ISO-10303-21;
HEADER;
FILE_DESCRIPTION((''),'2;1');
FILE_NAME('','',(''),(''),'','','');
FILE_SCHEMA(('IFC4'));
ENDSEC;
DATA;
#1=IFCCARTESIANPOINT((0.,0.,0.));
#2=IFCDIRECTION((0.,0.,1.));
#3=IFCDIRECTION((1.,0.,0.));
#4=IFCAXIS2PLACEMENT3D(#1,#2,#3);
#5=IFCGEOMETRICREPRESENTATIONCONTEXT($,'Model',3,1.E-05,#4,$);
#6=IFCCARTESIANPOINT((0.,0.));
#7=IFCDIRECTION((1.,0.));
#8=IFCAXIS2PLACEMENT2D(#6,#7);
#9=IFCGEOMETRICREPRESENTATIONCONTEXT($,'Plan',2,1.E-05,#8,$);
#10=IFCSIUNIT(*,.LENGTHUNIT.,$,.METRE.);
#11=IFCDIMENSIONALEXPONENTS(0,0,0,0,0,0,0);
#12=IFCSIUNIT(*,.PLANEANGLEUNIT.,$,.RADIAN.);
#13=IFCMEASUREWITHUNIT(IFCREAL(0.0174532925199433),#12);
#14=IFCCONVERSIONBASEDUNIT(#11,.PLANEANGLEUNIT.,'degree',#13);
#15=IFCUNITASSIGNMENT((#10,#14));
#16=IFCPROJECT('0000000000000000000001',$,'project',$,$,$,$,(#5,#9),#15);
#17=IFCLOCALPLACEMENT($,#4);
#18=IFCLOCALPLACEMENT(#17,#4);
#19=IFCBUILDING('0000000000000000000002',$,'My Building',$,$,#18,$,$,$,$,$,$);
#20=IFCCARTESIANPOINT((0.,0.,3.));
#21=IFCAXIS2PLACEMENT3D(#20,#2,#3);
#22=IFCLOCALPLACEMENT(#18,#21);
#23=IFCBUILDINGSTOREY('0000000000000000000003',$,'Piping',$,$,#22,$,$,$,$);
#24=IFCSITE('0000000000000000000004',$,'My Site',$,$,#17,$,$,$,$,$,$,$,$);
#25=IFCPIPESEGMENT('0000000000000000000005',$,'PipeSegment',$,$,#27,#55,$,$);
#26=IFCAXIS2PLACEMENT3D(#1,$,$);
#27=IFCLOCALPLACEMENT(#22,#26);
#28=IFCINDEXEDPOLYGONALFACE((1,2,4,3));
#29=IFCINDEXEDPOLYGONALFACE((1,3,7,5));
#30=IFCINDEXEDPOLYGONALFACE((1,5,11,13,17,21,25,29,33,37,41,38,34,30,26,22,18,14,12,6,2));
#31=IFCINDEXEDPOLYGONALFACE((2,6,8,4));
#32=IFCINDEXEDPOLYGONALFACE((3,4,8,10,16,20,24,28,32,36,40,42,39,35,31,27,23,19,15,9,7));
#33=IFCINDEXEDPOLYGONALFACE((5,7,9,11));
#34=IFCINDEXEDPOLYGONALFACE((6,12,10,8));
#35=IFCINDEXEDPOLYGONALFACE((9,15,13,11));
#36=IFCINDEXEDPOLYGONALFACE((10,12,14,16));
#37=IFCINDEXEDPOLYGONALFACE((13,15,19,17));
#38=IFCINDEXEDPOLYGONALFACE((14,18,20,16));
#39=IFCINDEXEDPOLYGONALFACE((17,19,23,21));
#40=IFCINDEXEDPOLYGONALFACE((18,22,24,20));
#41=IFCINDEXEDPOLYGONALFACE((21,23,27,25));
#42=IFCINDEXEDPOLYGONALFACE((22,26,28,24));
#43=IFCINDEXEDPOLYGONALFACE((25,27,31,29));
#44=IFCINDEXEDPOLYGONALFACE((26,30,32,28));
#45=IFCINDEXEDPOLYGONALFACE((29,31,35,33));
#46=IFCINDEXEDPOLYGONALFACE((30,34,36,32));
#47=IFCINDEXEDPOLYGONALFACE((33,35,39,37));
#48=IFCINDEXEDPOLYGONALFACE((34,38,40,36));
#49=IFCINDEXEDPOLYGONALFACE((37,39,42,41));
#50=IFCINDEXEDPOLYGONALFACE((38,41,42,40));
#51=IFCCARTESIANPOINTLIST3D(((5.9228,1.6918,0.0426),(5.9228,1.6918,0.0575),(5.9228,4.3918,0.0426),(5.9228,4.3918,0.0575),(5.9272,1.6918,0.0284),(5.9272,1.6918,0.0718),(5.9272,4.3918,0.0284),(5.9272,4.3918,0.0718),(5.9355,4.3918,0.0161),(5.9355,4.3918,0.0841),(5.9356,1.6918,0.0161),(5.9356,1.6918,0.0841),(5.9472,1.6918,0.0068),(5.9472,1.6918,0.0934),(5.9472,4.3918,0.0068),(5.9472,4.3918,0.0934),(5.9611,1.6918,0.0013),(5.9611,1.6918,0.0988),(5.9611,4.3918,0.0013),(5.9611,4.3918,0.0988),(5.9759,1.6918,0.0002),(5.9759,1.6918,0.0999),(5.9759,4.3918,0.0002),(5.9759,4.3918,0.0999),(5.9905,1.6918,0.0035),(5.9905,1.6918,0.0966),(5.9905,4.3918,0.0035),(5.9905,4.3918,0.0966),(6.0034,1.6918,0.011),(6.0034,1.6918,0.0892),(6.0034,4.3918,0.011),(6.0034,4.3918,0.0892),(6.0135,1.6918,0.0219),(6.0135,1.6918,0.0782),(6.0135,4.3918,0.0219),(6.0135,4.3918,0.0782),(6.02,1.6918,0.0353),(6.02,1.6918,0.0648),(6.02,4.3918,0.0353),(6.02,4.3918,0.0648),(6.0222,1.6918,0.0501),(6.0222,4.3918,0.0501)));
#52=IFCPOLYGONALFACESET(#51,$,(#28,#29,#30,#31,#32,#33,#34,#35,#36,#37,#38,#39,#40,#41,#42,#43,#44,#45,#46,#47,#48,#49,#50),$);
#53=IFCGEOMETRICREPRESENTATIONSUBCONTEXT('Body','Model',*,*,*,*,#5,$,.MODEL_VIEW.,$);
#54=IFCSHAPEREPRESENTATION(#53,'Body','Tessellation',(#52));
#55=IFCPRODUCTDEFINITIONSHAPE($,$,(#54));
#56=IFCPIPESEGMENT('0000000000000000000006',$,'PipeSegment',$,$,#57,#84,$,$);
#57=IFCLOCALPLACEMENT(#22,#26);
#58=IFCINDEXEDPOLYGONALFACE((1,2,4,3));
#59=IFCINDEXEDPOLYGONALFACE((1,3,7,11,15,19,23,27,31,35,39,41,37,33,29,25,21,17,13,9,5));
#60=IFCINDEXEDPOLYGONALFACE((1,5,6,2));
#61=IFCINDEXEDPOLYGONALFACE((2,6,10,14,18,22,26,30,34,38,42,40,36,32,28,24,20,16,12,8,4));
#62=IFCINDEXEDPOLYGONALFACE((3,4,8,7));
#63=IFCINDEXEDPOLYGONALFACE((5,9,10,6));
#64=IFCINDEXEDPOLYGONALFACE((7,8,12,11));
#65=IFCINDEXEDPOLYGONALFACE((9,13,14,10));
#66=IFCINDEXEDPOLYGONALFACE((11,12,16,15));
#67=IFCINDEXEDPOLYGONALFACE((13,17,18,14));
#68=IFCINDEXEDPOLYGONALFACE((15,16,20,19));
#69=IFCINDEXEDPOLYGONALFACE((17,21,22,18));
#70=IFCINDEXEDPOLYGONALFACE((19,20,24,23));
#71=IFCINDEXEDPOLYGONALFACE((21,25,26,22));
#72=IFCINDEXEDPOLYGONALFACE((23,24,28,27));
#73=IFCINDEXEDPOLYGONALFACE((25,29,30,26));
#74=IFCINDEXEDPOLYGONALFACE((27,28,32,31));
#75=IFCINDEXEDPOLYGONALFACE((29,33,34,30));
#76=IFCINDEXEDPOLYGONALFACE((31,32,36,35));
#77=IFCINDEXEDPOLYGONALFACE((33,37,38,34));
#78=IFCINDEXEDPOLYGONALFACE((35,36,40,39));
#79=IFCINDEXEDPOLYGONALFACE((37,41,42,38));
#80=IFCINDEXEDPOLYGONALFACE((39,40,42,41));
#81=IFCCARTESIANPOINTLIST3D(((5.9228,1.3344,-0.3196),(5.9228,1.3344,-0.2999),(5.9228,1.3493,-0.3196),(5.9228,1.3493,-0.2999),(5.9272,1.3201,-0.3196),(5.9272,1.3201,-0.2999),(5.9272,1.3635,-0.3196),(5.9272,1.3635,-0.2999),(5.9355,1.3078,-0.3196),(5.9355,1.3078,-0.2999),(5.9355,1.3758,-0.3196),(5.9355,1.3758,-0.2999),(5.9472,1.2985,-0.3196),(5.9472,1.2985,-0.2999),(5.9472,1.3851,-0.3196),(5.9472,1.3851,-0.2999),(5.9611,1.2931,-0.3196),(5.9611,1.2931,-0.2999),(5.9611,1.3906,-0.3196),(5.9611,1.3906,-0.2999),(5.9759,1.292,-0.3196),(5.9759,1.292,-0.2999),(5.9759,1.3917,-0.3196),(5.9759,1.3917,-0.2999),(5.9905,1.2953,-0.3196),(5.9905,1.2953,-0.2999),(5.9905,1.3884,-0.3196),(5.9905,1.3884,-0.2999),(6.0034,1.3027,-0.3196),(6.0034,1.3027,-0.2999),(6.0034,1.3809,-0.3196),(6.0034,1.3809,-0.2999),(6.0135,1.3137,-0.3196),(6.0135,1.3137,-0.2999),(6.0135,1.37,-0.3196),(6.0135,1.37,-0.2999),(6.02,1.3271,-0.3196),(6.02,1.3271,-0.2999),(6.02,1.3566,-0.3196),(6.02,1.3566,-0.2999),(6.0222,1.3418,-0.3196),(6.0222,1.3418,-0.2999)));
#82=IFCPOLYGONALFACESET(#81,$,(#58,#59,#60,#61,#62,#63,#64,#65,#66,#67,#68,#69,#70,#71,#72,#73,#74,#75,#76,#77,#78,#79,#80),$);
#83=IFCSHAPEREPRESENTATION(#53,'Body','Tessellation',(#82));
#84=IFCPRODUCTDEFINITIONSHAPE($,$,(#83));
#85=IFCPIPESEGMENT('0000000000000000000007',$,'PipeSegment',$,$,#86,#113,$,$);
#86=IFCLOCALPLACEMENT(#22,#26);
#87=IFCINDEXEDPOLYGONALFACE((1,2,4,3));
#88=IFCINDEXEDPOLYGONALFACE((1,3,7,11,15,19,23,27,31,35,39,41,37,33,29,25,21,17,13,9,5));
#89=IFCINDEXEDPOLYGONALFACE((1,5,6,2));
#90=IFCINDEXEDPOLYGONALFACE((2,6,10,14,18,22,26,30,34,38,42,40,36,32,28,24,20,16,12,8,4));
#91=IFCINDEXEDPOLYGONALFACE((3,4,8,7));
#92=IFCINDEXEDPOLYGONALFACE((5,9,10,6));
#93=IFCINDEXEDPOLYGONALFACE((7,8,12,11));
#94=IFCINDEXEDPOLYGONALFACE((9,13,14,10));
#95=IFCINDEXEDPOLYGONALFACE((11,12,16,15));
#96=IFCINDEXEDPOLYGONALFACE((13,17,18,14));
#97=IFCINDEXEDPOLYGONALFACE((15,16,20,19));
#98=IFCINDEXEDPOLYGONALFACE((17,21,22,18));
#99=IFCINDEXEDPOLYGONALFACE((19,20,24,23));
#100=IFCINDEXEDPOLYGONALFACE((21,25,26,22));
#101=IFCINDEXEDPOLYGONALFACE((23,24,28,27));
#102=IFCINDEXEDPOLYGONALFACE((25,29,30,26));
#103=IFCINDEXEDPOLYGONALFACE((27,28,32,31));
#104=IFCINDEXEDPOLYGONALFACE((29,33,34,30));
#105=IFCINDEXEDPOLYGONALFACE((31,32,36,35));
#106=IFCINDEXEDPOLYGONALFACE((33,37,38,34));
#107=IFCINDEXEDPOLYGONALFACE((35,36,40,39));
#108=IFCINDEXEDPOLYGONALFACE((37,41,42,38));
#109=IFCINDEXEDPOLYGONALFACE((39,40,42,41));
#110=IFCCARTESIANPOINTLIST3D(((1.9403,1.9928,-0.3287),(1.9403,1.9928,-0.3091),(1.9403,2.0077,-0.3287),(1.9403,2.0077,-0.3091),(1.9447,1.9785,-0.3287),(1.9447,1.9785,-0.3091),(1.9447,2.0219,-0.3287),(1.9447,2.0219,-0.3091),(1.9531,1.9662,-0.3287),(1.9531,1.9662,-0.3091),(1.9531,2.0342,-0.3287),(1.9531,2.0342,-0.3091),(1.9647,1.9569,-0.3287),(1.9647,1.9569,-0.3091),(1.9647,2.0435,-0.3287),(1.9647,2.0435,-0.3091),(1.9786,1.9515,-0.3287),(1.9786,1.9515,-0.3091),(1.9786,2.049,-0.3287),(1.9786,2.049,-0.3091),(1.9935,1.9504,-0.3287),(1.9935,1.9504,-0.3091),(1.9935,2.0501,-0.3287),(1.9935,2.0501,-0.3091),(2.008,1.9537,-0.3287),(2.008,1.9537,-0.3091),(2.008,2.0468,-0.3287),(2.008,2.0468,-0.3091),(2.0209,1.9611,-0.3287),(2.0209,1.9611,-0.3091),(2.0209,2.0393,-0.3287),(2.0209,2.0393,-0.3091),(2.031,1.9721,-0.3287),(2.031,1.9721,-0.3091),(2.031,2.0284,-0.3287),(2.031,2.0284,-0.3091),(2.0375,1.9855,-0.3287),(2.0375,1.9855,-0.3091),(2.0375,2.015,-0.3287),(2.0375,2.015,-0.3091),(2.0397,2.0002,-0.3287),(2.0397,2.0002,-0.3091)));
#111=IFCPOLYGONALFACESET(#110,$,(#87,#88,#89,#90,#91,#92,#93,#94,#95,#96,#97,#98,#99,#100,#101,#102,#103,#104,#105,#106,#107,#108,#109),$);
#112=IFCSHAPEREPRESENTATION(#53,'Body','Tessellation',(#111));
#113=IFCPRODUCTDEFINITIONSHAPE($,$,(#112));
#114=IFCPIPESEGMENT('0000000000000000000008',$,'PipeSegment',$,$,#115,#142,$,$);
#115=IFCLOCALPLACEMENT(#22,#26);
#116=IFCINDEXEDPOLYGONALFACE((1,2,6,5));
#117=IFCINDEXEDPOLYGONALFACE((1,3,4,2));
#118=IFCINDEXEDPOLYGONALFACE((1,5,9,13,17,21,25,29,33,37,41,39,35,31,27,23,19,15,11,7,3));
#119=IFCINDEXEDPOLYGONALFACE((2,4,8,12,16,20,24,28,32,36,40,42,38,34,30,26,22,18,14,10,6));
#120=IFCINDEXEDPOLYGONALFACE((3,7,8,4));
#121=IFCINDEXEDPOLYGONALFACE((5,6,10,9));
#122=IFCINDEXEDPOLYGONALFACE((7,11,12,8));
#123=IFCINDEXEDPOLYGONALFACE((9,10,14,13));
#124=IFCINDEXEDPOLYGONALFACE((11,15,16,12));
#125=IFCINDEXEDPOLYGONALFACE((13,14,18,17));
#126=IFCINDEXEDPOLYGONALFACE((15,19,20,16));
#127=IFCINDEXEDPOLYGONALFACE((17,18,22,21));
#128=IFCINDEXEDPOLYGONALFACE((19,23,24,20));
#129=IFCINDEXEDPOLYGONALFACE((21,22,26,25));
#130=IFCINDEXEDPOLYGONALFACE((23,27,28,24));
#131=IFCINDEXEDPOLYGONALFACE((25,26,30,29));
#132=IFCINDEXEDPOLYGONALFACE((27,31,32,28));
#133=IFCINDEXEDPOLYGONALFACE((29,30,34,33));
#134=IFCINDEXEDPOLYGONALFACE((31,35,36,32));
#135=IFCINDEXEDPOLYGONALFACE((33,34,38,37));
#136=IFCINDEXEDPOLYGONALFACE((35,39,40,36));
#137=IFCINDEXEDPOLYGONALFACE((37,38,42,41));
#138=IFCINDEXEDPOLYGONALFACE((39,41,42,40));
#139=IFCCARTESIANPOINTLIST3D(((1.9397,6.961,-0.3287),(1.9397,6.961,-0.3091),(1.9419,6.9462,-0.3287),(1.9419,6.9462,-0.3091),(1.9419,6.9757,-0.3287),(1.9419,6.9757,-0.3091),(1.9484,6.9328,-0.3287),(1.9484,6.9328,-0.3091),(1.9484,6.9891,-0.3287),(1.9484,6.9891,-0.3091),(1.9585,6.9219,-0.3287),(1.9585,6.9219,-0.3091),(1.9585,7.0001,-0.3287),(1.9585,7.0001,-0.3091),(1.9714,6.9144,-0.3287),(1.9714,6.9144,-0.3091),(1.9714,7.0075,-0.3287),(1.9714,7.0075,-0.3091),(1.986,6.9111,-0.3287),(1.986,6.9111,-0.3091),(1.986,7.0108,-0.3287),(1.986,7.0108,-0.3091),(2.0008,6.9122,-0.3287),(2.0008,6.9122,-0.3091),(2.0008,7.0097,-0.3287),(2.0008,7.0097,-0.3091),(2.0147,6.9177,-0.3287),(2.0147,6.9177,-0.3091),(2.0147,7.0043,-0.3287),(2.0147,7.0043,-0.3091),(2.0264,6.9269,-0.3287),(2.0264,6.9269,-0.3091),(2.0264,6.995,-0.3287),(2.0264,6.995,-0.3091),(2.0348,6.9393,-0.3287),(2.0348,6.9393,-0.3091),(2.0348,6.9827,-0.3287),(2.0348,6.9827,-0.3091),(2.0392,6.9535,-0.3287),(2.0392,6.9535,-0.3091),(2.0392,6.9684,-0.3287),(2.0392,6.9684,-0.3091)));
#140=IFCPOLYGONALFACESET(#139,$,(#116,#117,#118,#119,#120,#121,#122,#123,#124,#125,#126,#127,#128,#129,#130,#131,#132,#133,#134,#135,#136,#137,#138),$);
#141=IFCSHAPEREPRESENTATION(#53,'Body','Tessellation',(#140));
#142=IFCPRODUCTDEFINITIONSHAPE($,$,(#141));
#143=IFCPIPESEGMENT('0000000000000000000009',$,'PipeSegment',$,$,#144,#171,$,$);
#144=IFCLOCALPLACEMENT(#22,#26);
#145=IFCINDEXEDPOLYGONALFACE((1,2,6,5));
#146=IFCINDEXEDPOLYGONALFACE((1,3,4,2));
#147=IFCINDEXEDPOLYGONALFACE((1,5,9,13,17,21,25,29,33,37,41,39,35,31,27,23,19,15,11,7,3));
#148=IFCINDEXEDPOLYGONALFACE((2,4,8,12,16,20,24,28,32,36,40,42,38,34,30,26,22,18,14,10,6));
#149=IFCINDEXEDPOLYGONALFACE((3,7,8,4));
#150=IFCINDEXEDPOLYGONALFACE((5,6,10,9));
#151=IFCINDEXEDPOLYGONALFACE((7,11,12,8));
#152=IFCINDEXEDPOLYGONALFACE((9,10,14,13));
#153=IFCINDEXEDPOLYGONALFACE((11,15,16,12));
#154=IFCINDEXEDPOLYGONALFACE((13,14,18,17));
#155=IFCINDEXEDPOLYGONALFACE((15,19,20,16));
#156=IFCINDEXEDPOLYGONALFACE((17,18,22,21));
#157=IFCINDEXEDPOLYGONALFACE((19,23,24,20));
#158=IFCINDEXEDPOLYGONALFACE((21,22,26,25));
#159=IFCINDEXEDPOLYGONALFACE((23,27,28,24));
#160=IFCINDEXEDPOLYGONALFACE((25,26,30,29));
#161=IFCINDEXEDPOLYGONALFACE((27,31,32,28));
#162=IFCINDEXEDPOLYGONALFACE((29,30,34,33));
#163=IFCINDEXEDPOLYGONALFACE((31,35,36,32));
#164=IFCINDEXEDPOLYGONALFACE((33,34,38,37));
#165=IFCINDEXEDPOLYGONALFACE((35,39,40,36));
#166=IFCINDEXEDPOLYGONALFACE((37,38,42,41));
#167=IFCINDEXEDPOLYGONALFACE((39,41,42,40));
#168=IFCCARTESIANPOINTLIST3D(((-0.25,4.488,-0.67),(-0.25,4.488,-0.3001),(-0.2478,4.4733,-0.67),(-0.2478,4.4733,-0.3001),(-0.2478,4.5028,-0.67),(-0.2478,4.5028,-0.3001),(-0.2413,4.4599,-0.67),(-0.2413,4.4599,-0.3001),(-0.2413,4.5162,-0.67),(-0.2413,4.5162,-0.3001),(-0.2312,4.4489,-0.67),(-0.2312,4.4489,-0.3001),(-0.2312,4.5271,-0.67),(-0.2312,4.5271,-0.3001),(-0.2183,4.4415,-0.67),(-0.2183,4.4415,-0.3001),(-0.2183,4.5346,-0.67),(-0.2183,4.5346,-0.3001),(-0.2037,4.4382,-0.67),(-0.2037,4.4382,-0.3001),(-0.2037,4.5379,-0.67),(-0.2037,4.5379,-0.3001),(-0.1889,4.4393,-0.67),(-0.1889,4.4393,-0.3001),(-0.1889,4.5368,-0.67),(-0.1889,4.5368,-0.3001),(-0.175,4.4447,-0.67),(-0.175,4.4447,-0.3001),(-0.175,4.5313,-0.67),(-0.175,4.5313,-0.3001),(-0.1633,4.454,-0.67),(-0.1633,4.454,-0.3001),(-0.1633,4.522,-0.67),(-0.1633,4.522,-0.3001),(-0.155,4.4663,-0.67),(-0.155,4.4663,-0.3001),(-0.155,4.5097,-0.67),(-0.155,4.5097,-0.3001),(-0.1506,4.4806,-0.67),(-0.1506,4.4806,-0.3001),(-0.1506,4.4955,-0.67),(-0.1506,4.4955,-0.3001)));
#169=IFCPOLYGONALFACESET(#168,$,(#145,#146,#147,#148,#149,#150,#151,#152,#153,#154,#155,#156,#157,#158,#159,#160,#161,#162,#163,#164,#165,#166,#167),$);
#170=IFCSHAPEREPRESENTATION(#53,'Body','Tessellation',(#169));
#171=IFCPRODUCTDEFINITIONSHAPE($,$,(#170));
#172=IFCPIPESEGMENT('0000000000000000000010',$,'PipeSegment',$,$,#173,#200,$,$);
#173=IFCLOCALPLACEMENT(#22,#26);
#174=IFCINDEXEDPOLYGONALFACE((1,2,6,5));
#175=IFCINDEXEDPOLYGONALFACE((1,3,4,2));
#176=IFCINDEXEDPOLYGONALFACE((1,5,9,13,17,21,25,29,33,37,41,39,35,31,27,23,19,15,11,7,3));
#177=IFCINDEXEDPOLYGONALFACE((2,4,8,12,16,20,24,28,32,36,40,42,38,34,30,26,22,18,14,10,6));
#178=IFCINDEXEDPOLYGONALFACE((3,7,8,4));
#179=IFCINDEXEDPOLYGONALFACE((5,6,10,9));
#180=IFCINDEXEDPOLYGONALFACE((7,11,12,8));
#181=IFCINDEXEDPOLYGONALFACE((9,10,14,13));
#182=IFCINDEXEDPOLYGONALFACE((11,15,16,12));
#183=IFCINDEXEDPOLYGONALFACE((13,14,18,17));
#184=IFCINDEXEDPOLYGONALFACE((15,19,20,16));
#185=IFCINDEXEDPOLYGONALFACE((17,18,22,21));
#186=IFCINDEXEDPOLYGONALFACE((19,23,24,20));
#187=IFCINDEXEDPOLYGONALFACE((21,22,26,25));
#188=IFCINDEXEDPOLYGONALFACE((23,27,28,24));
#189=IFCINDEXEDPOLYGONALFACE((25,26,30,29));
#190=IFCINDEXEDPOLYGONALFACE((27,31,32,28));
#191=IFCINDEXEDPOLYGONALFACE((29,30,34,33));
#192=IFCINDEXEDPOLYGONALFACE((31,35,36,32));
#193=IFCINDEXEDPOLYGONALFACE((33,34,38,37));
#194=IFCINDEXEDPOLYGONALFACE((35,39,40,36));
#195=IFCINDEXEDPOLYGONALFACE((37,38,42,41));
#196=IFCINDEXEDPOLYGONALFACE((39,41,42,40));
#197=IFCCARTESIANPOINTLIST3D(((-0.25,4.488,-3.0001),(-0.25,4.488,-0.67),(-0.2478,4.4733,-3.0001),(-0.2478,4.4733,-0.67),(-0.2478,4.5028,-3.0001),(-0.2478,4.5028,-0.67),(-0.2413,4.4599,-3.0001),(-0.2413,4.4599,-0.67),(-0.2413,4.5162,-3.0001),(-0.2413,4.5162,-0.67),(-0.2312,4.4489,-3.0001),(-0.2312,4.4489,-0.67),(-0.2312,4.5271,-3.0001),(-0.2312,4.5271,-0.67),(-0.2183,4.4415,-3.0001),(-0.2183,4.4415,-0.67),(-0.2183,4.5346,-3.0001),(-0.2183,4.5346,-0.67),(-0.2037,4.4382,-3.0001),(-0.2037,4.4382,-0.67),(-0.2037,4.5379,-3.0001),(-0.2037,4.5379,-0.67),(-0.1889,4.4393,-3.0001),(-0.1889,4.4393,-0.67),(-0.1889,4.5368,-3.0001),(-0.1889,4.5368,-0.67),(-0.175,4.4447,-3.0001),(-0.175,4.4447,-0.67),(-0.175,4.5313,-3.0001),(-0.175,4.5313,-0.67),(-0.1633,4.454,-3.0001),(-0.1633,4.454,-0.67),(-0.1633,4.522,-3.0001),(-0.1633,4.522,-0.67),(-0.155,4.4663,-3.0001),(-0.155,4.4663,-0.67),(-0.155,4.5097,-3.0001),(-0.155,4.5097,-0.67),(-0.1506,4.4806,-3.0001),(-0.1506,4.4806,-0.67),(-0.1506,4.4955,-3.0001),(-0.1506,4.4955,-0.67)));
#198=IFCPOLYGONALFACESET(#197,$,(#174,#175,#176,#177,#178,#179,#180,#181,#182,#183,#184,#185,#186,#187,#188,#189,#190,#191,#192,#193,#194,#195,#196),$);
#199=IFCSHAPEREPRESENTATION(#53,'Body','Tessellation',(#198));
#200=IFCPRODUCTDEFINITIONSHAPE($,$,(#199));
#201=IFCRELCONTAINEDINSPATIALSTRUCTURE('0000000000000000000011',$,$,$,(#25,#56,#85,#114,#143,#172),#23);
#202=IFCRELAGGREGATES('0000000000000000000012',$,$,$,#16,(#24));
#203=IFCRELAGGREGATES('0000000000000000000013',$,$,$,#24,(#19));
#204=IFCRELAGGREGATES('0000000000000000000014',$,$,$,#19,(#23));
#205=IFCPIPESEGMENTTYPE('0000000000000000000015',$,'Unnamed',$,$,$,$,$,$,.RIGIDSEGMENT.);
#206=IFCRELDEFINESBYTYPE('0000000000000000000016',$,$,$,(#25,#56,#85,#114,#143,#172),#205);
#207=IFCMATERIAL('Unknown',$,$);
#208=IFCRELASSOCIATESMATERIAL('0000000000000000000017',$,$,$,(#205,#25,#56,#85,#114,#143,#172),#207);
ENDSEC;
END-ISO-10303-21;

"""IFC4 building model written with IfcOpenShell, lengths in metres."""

from ifc_helpers import new_model, entity, si_unit, converted_unit, frame, origin_with_axes, origin_2d_with_axis, place, context, subcontext, project, spatial, circle, extrude, material, material_profile, profile_set, profile_usage, type_object, element, save


model = new_model("IFC4")

# Units and contexts
model_context = context("Model", 3, precision=1e-05, world=origin_with_axes())
plan_context = context("Plan", 2, precision=1e-05, world=origin_2d_with_axis())
body_context = subcontext(model_context, "Body", "Model", "MODEL_VIEW")
ifc_project = project(units=[si_unit("LENGTHUNIT", "METRE"), converted_unit("PLANEANGLEUNIT", "degree", entity("IfcReal", 0.0174532925199433), si_unit("PLANEANGLEUNIT", "RADIAN"), dimensions=[0, 0, 0, 0, 0, 0, 0])], contexts=[model_context, plan_context])

# Site, building, storey
site_placement = place(None, origin_with_axes())
site = spatial("IfcSite", under=ifc_project, at=site_placement, Name="My Site")
building_placement = place(site_placement, origin_with_axes())
building = spatial("IfcBuilding", under=site, at=building_placement, Name="My Building")
storey_placement = place(building_placement, frame((0.0, 0.0, 3.0), z_axis=(0.0, 0.0, 1.0), x_axis=(1.0, 0.0, 0.0)))
storey = spatial("IfcBuildingStorey", under=building, at=storey_placement, Name="Piping")

# Pipe segments
ifc_material = material(Name="Unknown")
ifc_material_profile_1 = material_profile(ifc_material, circle(Radius=0.05))
ifc_profile_set_1 = profile_set([ifc_material_profile_1])
pipe_segment_type = type_object("IfcPipeSegmentType", Name="Unnamed", PredefinedType="RIGIDSEGMENT", material=ifc_profile_set_1)
ifc_profile_usage_1 = profile_usage(ifc_profile_set_1, cardinal=5)
pipe_segment_1_placement = place(storey_placement, frame((5.9722, 4.3918, 0.0501), z_axis=(0.0, -1.0, 0.0), x_axis=(1.0, 0.0, 0.0)))
element("IfcPipeSegment", 1, at=pipe_segment_1_placement, inside=storey, type_object=pipe_segment_type, material=ifc_profile_usage_1, Name="PipeSegment", context=body_context, shape_type="SweptSolid", body=[
    extrude(circle(Radius=0.05), origin_with_axes(), (0.0, 0.0, 1.0), 2.7),
])
ifc_profile_usage_2 = profile_usage(ifc_profile_set_1, cardinal=15)
pipe_segment_2_placement = place(storey_placement, frame((5.9722, 1.3418, -0.2999), z_axis=(0.0, 0.0, -1.0), x_axis=(1.0, 0.0, 0.0)))
element("IfcPipeSegment", 2, at=pipe_segment_2_placement, inside=storey, type_object=pipe_segment_type, material=ifc_profile_usage_2, Name="PipeSegment", context=body_context, shape_type="SweptSolid", body=[
    extrude(circle(Radius=0.05), origin_with_axes(), (0.0, 0.0, 1.0), 0.0196),
])
ifc_profile_usage_3 = profile_usage(ifc_profile_set_1, cardinal=15)
pipe_segment_3_placement = place(storey_placement, frame((1.9897, 2.0002, -0.3091), z_axis=(0.0, 0.0, -1.0), x_axis=(1.0, 0.0, 0.0)))
element("IfcPipeSegment", 3, at=pipe_segment_3_placement, inside=storey, type_object=pipe_segment_type, material=ifc_profile_usage_3, Name="PipeSegment", context=body_context, shape_type="SweptSolid", body=[
    extrude(circle(Radius=0.05), origin_with_axes(), (0.0, 0.0, 1.0), 0.0196),
])
ifc_profile_usage_4 = profile_usage(ifc_profile_set_1, cardinal=15)
pipe_segment_4_placement = place(storey_placement, frame((1.9897, 6.961, -0.3091), z_axis=(0.000001, 0.0, -1.0), x_axis=(-1.0, 0.0, -0.000001)))
element("IfcPipeSegment", 4, at=pipe_segment_4_placement, inside=storey, type_object=pipe_segment_type, material=ifc_profile_usage_4, Name="PipeSegment", context=body_context, shape_type="SweptSolid", body=[
    extrude(circle(Radius=0.05), origin_with_axes(), (0.0, 0.0, 1.0), 0.0196),
])
ifc_profile_usage_5 = profile_usage(ifc_profile_set_1, cardinal=15)
pipe_segment_5_placement = place(storey_placement, frame((-0.2, 4.488, -0.3001), z_axis=(0.0, 0.0, -1.0), x_axis=(-1.0, 0.0, 0.0)))
element("IfcPipeSegment", 5, at=pipe_segment_5_placement, inside=storey, type_object=pipe_segment_type, material=ifc_profile_usage_5, Name="PipeSegment", context=body_context, shape_type="SweptSolid", body=[
    extrude(circle(Radius=0.05), origin_with_axes(), (0.0, 0.0, 1.0), 0.3699),
])
ifc_profile_usage_6 = profile_usage(ifc_profile_set_1, cardinal=15)
pipe_segment_6_placement = place(storey_placement, frame((-0.2, 4.488, -0.67), z_axis=(0.0, 0.0, -1.0), x_axis=(-1.0, 0.0, 0.0)))
element("IfcPipeSegment", 6, at=pipe_segment_6_placement, inside=storey, type_object=pipe_segment_type, material=ifc_profile_usage_6, Name="PipeSegment", context=body_context, shape_type="SweptSolid", body=[
    extrude(circle(Radius=0.05), origin_with_axes(), (0.0, 0.0, 1.0), 2.3301),
])

save(model, "model.ifc")
